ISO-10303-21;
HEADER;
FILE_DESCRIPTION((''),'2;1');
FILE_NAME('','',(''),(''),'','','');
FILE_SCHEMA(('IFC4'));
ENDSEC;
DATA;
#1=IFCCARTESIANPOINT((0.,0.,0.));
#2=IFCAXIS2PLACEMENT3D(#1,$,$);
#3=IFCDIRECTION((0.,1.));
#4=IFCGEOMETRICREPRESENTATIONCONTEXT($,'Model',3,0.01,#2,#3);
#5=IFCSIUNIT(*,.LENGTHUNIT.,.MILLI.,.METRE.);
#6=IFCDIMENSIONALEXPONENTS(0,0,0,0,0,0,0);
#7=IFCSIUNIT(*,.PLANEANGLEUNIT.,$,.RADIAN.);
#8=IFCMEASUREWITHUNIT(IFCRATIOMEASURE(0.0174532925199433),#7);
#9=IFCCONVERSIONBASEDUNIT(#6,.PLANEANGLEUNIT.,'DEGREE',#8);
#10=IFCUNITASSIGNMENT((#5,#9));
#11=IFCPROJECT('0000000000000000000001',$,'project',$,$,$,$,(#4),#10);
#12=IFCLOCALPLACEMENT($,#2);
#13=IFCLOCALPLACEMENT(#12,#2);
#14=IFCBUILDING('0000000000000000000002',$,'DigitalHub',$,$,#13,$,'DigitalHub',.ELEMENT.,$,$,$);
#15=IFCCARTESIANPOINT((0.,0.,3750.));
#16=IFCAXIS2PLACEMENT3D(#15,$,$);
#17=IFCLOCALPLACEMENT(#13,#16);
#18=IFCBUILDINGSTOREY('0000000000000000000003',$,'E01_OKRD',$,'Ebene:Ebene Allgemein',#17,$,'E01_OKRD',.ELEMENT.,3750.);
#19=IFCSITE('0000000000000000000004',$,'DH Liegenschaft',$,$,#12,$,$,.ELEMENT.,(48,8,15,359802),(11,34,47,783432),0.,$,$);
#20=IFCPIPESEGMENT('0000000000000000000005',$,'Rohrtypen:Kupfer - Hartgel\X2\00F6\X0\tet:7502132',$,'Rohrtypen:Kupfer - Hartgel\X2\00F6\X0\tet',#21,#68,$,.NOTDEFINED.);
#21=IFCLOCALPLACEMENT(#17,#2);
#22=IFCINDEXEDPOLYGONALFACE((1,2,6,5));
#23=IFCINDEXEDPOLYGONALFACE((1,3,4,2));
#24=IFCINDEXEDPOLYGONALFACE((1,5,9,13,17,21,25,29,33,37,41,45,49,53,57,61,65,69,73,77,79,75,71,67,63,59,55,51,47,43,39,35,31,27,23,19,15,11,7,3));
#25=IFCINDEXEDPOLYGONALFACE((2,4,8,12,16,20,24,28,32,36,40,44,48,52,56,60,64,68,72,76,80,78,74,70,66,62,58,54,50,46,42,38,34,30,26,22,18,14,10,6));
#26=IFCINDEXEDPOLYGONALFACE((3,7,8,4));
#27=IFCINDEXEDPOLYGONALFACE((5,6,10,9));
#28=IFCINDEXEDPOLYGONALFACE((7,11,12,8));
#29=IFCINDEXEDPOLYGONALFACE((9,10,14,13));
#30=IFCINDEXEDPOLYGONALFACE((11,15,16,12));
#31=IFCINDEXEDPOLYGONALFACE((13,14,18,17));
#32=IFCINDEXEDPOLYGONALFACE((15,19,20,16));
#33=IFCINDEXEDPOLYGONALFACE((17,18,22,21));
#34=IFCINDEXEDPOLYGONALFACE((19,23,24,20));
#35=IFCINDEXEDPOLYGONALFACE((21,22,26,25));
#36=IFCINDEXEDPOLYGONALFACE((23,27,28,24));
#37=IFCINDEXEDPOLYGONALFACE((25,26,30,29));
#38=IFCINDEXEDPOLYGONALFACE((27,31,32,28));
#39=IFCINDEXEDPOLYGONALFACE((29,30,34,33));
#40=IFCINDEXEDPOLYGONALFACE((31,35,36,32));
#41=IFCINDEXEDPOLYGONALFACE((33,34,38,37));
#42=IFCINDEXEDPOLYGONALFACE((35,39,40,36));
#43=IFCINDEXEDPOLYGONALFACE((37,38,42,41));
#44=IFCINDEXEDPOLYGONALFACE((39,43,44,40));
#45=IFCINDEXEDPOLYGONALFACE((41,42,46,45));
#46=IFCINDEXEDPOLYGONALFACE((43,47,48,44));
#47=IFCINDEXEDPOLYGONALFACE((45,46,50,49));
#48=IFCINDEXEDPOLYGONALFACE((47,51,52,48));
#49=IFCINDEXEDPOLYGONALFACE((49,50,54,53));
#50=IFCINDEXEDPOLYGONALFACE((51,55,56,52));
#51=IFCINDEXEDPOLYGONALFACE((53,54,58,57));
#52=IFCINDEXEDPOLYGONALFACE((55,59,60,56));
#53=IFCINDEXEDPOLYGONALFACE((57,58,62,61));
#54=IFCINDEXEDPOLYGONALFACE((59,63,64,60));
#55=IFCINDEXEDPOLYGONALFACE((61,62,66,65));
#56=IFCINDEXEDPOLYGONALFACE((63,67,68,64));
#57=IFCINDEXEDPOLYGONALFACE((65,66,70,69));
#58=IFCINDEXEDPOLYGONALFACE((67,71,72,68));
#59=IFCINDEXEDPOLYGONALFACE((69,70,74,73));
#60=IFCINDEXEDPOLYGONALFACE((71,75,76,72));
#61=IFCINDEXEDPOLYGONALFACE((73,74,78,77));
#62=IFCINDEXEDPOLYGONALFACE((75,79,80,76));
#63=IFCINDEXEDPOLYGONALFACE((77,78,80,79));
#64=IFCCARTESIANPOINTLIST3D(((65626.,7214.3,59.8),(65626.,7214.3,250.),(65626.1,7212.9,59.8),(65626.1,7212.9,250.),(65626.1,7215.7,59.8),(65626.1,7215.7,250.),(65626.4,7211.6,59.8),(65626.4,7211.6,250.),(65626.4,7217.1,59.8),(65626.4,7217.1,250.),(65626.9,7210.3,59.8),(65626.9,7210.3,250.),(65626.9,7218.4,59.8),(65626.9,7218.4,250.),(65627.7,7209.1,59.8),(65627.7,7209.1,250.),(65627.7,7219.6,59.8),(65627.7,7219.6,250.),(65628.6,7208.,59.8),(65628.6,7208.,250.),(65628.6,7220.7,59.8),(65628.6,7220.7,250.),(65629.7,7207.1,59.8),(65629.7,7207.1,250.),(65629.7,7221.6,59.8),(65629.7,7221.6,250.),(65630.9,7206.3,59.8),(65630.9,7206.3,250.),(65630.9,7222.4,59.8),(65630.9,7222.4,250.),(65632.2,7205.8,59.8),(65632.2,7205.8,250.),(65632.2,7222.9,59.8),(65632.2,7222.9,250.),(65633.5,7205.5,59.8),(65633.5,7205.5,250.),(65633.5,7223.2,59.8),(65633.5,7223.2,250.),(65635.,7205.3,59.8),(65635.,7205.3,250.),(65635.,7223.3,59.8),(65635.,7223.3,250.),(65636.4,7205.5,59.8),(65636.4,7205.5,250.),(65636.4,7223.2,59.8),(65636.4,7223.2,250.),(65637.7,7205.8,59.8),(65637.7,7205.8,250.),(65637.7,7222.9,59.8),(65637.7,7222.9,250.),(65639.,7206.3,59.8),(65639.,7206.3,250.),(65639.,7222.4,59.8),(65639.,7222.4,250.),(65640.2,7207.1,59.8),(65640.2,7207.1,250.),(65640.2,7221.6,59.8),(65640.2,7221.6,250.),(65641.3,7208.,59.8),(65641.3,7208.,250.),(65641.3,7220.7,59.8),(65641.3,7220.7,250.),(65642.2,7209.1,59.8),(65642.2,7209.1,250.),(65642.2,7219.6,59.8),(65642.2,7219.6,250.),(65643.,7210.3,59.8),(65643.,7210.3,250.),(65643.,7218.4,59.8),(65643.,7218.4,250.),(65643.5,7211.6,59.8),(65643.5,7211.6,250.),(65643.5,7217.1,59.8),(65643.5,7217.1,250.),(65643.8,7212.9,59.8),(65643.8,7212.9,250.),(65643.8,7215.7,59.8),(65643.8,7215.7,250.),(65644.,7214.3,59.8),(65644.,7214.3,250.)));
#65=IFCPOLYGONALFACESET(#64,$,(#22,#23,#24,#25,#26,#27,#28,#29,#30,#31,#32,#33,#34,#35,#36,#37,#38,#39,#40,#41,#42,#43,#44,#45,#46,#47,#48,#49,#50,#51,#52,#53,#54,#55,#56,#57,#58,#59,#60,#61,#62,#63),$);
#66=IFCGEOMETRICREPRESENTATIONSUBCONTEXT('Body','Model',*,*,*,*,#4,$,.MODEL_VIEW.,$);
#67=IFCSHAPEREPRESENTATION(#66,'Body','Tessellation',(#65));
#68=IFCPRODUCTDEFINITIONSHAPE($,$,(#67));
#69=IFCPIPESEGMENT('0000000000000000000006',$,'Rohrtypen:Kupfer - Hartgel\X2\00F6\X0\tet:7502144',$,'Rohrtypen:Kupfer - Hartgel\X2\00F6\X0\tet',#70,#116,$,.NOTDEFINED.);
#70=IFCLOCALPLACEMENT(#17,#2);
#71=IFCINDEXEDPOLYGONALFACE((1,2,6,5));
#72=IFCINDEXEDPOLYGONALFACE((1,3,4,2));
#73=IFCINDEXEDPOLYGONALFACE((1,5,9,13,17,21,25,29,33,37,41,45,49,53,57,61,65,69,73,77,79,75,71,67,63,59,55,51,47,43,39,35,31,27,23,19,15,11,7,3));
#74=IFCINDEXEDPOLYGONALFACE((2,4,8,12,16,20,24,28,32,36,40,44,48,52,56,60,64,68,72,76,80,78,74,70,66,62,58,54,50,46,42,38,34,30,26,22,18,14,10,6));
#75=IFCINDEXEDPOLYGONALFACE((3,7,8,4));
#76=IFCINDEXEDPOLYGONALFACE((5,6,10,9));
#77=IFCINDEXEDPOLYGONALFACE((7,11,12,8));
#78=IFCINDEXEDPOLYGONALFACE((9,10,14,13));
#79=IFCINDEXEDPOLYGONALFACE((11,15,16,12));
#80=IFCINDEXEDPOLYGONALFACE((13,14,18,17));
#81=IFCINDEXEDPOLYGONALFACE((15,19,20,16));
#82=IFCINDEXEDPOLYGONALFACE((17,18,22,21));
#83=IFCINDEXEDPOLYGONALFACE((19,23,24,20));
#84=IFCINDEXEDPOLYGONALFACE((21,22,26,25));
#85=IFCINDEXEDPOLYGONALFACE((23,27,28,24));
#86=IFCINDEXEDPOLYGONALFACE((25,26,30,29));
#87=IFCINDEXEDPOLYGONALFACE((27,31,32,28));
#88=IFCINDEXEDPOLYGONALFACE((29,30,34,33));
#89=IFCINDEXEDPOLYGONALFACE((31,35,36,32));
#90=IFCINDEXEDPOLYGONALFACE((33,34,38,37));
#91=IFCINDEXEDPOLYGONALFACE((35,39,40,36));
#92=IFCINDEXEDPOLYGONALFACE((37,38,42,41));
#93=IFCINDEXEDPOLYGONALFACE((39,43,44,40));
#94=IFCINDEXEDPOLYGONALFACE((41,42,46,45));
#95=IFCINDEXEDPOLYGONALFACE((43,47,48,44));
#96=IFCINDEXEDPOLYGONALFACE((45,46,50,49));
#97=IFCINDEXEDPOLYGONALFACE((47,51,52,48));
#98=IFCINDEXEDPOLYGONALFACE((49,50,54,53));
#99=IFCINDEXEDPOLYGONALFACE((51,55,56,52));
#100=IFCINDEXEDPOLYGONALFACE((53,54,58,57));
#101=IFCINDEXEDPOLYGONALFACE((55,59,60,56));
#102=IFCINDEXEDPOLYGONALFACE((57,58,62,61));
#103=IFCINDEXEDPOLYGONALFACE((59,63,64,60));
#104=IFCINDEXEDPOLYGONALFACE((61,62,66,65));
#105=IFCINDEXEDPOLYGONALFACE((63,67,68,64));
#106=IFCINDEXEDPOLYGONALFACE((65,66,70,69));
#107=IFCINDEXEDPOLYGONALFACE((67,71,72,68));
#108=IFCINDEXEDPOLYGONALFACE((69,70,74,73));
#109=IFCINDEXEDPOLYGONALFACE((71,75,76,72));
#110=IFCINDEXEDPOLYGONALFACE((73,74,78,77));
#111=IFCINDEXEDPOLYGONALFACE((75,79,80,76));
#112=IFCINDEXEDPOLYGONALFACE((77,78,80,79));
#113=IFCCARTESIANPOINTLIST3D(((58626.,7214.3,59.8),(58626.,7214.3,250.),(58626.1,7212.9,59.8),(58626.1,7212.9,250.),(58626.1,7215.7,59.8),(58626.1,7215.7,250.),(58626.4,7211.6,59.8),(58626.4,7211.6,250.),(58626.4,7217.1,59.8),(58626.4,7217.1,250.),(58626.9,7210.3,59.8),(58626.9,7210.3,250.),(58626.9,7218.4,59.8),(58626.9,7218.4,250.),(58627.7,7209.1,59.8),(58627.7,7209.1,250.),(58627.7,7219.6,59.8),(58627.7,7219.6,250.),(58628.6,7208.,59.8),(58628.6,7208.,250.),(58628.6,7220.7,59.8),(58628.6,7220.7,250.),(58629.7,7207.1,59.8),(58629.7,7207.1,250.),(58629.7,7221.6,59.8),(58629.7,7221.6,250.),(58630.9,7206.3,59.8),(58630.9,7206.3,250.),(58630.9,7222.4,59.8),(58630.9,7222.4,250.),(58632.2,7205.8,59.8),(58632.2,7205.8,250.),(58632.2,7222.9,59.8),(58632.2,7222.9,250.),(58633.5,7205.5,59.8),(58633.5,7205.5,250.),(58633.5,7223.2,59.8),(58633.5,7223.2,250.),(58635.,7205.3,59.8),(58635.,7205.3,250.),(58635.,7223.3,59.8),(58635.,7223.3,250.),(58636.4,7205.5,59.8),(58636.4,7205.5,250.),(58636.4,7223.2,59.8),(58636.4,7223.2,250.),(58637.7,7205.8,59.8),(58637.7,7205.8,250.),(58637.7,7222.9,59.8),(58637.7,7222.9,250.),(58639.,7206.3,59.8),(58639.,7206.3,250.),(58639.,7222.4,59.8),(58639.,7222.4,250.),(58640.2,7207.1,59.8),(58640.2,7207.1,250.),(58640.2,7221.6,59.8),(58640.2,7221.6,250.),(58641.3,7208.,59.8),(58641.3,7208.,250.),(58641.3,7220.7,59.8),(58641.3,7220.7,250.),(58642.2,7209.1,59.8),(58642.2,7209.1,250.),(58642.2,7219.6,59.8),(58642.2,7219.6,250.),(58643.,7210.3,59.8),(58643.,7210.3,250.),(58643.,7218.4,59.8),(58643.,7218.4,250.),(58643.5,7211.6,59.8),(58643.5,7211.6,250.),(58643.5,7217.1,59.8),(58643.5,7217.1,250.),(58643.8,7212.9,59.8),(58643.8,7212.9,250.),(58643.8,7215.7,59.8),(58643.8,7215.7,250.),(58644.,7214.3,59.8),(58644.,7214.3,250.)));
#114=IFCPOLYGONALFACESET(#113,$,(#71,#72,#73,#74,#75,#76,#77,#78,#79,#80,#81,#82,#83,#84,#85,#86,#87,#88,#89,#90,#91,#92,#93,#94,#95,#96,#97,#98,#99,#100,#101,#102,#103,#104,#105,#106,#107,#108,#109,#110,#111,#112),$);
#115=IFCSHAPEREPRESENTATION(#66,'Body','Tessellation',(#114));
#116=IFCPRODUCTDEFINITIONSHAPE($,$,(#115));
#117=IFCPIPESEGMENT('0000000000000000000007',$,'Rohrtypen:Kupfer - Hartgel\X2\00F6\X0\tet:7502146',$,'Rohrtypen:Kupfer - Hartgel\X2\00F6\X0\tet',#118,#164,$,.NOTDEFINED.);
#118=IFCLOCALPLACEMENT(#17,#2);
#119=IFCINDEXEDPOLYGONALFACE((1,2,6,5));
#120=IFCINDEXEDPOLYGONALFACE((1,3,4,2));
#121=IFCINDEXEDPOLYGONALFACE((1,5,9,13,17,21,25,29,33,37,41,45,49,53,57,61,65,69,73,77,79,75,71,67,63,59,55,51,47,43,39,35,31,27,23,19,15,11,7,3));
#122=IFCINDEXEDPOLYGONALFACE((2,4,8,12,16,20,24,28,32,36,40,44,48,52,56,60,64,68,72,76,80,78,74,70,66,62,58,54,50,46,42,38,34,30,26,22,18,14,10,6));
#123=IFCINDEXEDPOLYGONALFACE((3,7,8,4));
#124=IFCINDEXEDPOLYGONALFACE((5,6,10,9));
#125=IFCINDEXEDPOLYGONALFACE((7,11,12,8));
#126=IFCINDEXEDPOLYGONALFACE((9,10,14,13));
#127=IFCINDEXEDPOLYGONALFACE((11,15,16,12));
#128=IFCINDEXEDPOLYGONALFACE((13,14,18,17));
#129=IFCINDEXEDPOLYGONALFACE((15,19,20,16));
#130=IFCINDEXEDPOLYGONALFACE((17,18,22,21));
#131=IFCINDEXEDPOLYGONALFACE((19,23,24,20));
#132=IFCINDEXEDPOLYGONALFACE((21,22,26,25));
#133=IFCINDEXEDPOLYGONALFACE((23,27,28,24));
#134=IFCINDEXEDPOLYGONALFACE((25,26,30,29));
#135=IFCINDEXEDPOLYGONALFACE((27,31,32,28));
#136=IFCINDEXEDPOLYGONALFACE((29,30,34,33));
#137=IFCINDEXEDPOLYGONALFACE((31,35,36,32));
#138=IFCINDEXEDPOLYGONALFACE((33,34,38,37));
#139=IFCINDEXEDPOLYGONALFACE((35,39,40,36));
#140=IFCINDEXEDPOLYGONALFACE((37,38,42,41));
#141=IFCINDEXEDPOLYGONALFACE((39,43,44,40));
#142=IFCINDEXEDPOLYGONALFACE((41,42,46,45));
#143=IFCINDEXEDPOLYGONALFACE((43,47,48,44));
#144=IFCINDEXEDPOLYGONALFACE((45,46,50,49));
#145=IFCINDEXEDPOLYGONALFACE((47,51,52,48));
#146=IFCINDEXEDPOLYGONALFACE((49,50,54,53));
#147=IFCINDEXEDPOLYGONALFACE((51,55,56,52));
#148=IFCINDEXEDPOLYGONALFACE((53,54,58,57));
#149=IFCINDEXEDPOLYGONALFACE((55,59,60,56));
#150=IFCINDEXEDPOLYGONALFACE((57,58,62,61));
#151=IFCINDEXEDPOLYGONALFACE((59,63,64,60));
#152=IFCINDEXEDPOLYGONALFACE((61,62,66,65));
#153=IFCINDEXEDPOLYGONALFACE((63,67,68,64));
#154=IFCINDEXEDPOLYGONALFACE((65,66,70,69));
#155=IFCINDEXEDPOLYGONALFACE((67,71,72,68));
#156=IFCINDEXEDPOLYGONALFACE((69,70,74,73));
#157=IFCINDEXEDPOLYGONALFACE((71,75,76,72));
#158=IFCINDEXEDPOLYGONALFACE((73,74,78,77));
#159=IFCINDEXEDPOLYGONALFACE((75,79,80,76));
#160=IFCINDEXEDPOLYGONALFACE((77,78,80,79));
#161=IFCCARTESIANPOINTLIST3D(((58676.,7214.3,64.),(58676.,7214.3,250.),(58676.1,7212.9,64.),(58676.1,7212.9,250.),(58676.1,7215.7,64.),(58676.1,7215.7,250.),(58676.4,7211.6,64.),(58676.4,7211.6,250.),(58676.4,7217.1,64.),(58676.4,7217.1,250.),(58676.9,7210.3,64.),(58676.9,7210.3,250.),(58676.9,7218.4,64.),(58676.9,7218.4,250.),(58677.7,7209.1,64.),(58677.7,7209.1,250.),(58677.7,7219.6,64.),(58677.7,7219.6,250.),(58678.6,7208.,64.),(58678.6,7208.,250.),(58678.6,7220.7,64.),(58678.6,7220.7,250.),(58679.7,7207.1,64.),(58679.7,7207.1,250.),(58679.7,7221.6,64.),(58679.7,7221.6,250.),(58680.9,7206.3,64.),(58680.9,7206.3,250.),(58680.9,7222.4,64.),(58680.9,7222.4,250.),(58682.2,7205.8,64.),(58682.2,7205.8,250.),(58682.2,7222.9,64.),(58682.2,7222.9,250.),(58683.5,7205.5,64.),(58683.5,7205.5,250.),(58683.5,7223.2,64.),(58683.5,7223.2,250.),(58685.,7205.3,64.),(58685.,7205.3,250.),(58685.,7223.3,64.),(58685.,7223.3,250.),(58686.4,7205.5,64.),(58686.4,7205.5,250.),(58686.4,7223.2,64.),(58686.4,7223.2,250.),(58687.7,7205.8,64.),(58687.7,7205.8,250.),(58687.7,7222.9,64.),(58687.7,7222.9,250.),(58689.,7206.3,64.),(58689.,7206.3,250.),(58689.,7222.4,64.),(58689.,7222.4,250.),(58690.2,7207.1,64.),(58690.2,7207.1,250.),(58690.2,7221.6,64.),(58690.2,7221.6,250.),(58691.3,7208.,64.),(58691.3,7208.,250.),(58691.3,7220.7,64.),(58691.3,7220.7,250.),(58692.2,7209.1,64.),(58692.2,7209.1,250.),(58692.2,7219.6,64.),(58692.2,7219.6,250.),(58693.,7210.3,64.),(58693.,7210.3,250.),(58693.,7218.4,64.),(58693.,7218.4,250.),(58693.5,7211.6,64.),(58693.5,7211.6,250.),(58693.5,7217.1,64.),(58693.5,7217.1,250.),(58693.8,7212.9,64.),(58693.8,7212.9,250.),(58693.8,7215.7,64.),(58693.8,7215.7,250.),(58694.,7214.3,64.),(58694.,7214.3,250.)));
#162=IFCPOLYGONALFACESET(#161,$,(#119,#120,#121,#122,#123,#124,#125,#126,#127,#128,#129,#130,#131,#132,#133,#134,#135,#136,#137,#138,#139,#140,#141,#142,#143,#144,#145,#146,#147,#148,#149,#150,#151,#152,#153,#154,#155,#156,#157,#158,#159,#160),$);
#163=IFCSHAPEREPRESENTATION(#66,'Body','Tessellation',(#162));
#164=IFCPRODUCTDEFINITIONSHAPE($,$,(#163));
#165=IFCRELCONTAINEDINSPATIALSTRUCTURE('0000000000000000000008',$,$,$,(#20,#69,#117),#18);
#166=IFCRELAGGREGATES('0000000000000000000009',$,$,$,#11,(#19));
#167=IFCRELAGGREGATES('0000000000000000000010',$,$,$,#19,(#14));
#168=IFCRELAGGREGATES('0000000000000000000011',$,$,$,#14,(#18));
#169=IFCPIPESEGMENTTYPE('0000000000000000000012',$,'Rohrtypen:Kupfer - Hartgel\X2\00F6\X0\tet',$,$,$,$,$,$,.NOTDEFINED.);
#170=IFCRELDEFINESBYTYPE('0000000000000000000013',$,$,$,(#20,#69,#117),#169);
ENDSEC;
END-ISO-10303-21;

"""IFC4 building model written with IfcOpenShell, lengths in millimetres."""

from ifc_helpers import new_model, entity, si_unit, converted_unit, direction, frame, origin, place, context, subcontext, project, spatial, indexed_curve, outline, extrude, type_object, element, save


model = new_model("IFC4")

# Units and contexts
model_context = context("Model", 3, precision=0.01, world=origin(), true_north=direction((0.0, 1.0)))
body_context = subcontext(model_context, "Body", "Model", "MODEL_VIEW")
ifc_project = project(units=[si_unit("LENGTHUNIT", "METRE", prefix="MILLI"), converted_unit("PLANEANGLEUNIT", "DEGREE", entity("IfcRatioMeasure", 0.0174532925199433), si_unit("PLANEANGLEUNIT", "RADIAN"), dimensions=[0, 0, 0, 0, 0, 0, 0])], contexts=[model_context])

# Site, building, storey
site_placement = place(None, origin())
site = spatial("IfcSite", under=ifc_project, at=site_placement, Name="DH Liegenschaft", CompositionType="ELEMENT", RefLatitude=(48, 8, 15, 359802), RefLongitude=(11, 34, 47, 783432), RefElevation=0.0)
building_placement = place(site_placement, origin())
building = spatial("IfcBuilding", under=site, at=building_placement, Name="DigitalHub", LongName="DigitalHub", CompositionType="ELEMENT")
storey_placement = place(building_placement, frame((0.0, 0.0, 3750.0)))
storey = spatial("IfcBuildingStorey", under=building, at=storey_placement, Name="E01_OKRD", ObjectType="Ebene:Ebene Allgemein", LongName="E01_OKRD", CompositionType="ELEMENT", Elevation=3750.0)

# Pipe segments
pipe_segment_type = type_object("IfcPipeSegmentType", Name="Rohrtypen:Kupfer - Hartgelötet", PredefinedType="NOTDEFINED")
pipe_segment_1_placement = place(storey_placement, frame((65624.4, 7203.7, 59.8)))
element("IfcPipeSegment", 1, at=pipe_segment_1_placement, inside=storey, type_object=pipe_segment_type, Name="Rohrtypen:Kupfer - Hartgelötet:7502132", ObjectType="Rohrtypen:Kupfer - Hartgelötet", PredefinedType="NOTDEFINED", context=body_context, shape_type="SweptSolid", body=[
    extrude(outline(indexed_curve([(9.0, 0.0), (8.9, 1.4), (8.6, 2.8), (8.0, 4.1), (7.3, 5.3), (6.4, 6.4), (5.3, 7.3), (4.1, 8.0), (2.8, 8.6), (1.4, 8.9), (0.0, 9.0), (-1.4, 8.9), (-2.8, 8.6), (-4.1, 8.0), (-5.3, 7.3), (-6.4, 6.4), (-7.3, 5.3), (-8.0, 4.1), (-8.6, 2.8), (-8.9, 1.4), (-9.0, 0.0), (-8.9, -1.4), (-8.6, -2.8), (-8.0, -4.1), (-7.3, -5.3), (-6.4, -6.4), (-5.3, -7.3), (-4.1, -8.0), (-2.8, -8.6), (-1.4, -8.9), (0.0, -9.0), (1.4, -8.9), (2.8, -8.6), (4.1, -8.0), (5.3, -7.3), (6.4, -6.4), (7.3, -5.3), (8.0, -4.1), (8.6, -2.8), (8.9, -1.4), (9.0, 0.0)], self_intersect=False)), frame((10.6, 10.6, 0.0)), (0.0, 0.0, 1.0), 190.2),
])
pipe_segment_2_placement = place(storey_placement, frame((58624.4, 7203.7, 59.8)))
element("IfcPipeSegment", 2, at=pipe_segment_2_placement, inside=storey, type_object=pipe_segment_type, Name="Rohrtypen:Kupfer - Hartgelötet:7502144", ObjectType="Rohrtypen:Kupfer - Hartgelötet", PredefinedType="NOTDEFINED", context=body_context, shape_type="SweptSolid", body=[
    extrude(outline(indexed_curve([(9.0, 0.0), (8.9, 1.4), (8.6, 2.8), (8.0, 4.1), (7.3, 5.3), (6.4, 6.4), (5.3, 7.3), (4.1, 8.0), (2.8, 8.6), (1.4, 8.9), (0.0, 9.0), (-1.4, 8.9), (-2.8, 8.6), (-4.1, 8.0), (-5.3, 7.3), (-6.4, 6.4), (-7.3, 5.3), (-8.0, 4.1), (-8.6, 2.8), (-8.9, 1.4), (-9.0, 0.0), (-8.9, -1.4), (-8.6, -2.8), (-8.0, -4.1), (-7.3, -5.3), (-6.4, -6.4), (-5.3, -7.3), (-4.1, -8.0), (-2.8, -8.6), (-1.4, -8.9), (0.0, -9.0), (1.4, -8.9), (2.8, -8.6), (4.1, -8.0), (5.3, -7.3), (6.4, -6.4), (7.3, -5.3), (8.0, -4.1), (8.6, -2.8), (8.9, -1.4), (9.0, 0.0)], self_intersect=False)), frame((10.6, 10.6, 0.0)), (0.0, 0.0, 1.0), 190.2),
])
pipe_segment_3_placement = place(storey_placement, frame((58674.4, 7203.7, 64.0)))
element("IfcPipeSegment", 3, at=pipe_segment_3_placement, inside=storey, type_object=pipe_segment_type, Name="Rohrtypen:Kupfer - Hartgelötet:7502146", ObjectType="Rohrtypen:Kupfer - Hartgelötet", PredefinedType="NOTDEFINED", context=body_context, shape_type="SweptSolid", body=[
    extrude(outline(indexed_curve([(9.0, 0.0), (8.9, 1.4), (8.6, 2.8), (8.0, 4.1), (7.3, 5.3), (6.4, 6.4), (5.3, 7.3), (4.1, 8.0), (2.8, 8.6), (1.4, 8.9), (0.0, 9.0), (-1.4, 8.9), (-2.8, 8.6), (-4.1, 8.0), (-5.3, 7.3), (-6.4, 6.4), (-7.3, 5.3), (-8.0, 4.1), (-8.6, 2.8), (-8.9, 1.4), (-9.0, 0.0), (-8.9, -1.4), (-8.6, -2.8), (-8.0, -4.1), (-7.3, -5.3), (-6.4, -6.4), (-5.3, -7.3), (-4.1, -8.0), (-2.8, -8.6), (-1.4, -8.9), (0.0, -9.0), (1.4, -8.9), (2.8, -8.6), (4.1, -8.0), (5.3, -7.3), (6.4, -6.4), (7.3, -5.3), (8.0, -4.1), (8.6, -2.8), (8.9, -1.4), (9.0, 0.0)], self_intersect=False)), frame((10.6, 10.6, 0.0)), (0.0, 0.0, 1.0), 186.0),
])

save(model, "model.ifc")
